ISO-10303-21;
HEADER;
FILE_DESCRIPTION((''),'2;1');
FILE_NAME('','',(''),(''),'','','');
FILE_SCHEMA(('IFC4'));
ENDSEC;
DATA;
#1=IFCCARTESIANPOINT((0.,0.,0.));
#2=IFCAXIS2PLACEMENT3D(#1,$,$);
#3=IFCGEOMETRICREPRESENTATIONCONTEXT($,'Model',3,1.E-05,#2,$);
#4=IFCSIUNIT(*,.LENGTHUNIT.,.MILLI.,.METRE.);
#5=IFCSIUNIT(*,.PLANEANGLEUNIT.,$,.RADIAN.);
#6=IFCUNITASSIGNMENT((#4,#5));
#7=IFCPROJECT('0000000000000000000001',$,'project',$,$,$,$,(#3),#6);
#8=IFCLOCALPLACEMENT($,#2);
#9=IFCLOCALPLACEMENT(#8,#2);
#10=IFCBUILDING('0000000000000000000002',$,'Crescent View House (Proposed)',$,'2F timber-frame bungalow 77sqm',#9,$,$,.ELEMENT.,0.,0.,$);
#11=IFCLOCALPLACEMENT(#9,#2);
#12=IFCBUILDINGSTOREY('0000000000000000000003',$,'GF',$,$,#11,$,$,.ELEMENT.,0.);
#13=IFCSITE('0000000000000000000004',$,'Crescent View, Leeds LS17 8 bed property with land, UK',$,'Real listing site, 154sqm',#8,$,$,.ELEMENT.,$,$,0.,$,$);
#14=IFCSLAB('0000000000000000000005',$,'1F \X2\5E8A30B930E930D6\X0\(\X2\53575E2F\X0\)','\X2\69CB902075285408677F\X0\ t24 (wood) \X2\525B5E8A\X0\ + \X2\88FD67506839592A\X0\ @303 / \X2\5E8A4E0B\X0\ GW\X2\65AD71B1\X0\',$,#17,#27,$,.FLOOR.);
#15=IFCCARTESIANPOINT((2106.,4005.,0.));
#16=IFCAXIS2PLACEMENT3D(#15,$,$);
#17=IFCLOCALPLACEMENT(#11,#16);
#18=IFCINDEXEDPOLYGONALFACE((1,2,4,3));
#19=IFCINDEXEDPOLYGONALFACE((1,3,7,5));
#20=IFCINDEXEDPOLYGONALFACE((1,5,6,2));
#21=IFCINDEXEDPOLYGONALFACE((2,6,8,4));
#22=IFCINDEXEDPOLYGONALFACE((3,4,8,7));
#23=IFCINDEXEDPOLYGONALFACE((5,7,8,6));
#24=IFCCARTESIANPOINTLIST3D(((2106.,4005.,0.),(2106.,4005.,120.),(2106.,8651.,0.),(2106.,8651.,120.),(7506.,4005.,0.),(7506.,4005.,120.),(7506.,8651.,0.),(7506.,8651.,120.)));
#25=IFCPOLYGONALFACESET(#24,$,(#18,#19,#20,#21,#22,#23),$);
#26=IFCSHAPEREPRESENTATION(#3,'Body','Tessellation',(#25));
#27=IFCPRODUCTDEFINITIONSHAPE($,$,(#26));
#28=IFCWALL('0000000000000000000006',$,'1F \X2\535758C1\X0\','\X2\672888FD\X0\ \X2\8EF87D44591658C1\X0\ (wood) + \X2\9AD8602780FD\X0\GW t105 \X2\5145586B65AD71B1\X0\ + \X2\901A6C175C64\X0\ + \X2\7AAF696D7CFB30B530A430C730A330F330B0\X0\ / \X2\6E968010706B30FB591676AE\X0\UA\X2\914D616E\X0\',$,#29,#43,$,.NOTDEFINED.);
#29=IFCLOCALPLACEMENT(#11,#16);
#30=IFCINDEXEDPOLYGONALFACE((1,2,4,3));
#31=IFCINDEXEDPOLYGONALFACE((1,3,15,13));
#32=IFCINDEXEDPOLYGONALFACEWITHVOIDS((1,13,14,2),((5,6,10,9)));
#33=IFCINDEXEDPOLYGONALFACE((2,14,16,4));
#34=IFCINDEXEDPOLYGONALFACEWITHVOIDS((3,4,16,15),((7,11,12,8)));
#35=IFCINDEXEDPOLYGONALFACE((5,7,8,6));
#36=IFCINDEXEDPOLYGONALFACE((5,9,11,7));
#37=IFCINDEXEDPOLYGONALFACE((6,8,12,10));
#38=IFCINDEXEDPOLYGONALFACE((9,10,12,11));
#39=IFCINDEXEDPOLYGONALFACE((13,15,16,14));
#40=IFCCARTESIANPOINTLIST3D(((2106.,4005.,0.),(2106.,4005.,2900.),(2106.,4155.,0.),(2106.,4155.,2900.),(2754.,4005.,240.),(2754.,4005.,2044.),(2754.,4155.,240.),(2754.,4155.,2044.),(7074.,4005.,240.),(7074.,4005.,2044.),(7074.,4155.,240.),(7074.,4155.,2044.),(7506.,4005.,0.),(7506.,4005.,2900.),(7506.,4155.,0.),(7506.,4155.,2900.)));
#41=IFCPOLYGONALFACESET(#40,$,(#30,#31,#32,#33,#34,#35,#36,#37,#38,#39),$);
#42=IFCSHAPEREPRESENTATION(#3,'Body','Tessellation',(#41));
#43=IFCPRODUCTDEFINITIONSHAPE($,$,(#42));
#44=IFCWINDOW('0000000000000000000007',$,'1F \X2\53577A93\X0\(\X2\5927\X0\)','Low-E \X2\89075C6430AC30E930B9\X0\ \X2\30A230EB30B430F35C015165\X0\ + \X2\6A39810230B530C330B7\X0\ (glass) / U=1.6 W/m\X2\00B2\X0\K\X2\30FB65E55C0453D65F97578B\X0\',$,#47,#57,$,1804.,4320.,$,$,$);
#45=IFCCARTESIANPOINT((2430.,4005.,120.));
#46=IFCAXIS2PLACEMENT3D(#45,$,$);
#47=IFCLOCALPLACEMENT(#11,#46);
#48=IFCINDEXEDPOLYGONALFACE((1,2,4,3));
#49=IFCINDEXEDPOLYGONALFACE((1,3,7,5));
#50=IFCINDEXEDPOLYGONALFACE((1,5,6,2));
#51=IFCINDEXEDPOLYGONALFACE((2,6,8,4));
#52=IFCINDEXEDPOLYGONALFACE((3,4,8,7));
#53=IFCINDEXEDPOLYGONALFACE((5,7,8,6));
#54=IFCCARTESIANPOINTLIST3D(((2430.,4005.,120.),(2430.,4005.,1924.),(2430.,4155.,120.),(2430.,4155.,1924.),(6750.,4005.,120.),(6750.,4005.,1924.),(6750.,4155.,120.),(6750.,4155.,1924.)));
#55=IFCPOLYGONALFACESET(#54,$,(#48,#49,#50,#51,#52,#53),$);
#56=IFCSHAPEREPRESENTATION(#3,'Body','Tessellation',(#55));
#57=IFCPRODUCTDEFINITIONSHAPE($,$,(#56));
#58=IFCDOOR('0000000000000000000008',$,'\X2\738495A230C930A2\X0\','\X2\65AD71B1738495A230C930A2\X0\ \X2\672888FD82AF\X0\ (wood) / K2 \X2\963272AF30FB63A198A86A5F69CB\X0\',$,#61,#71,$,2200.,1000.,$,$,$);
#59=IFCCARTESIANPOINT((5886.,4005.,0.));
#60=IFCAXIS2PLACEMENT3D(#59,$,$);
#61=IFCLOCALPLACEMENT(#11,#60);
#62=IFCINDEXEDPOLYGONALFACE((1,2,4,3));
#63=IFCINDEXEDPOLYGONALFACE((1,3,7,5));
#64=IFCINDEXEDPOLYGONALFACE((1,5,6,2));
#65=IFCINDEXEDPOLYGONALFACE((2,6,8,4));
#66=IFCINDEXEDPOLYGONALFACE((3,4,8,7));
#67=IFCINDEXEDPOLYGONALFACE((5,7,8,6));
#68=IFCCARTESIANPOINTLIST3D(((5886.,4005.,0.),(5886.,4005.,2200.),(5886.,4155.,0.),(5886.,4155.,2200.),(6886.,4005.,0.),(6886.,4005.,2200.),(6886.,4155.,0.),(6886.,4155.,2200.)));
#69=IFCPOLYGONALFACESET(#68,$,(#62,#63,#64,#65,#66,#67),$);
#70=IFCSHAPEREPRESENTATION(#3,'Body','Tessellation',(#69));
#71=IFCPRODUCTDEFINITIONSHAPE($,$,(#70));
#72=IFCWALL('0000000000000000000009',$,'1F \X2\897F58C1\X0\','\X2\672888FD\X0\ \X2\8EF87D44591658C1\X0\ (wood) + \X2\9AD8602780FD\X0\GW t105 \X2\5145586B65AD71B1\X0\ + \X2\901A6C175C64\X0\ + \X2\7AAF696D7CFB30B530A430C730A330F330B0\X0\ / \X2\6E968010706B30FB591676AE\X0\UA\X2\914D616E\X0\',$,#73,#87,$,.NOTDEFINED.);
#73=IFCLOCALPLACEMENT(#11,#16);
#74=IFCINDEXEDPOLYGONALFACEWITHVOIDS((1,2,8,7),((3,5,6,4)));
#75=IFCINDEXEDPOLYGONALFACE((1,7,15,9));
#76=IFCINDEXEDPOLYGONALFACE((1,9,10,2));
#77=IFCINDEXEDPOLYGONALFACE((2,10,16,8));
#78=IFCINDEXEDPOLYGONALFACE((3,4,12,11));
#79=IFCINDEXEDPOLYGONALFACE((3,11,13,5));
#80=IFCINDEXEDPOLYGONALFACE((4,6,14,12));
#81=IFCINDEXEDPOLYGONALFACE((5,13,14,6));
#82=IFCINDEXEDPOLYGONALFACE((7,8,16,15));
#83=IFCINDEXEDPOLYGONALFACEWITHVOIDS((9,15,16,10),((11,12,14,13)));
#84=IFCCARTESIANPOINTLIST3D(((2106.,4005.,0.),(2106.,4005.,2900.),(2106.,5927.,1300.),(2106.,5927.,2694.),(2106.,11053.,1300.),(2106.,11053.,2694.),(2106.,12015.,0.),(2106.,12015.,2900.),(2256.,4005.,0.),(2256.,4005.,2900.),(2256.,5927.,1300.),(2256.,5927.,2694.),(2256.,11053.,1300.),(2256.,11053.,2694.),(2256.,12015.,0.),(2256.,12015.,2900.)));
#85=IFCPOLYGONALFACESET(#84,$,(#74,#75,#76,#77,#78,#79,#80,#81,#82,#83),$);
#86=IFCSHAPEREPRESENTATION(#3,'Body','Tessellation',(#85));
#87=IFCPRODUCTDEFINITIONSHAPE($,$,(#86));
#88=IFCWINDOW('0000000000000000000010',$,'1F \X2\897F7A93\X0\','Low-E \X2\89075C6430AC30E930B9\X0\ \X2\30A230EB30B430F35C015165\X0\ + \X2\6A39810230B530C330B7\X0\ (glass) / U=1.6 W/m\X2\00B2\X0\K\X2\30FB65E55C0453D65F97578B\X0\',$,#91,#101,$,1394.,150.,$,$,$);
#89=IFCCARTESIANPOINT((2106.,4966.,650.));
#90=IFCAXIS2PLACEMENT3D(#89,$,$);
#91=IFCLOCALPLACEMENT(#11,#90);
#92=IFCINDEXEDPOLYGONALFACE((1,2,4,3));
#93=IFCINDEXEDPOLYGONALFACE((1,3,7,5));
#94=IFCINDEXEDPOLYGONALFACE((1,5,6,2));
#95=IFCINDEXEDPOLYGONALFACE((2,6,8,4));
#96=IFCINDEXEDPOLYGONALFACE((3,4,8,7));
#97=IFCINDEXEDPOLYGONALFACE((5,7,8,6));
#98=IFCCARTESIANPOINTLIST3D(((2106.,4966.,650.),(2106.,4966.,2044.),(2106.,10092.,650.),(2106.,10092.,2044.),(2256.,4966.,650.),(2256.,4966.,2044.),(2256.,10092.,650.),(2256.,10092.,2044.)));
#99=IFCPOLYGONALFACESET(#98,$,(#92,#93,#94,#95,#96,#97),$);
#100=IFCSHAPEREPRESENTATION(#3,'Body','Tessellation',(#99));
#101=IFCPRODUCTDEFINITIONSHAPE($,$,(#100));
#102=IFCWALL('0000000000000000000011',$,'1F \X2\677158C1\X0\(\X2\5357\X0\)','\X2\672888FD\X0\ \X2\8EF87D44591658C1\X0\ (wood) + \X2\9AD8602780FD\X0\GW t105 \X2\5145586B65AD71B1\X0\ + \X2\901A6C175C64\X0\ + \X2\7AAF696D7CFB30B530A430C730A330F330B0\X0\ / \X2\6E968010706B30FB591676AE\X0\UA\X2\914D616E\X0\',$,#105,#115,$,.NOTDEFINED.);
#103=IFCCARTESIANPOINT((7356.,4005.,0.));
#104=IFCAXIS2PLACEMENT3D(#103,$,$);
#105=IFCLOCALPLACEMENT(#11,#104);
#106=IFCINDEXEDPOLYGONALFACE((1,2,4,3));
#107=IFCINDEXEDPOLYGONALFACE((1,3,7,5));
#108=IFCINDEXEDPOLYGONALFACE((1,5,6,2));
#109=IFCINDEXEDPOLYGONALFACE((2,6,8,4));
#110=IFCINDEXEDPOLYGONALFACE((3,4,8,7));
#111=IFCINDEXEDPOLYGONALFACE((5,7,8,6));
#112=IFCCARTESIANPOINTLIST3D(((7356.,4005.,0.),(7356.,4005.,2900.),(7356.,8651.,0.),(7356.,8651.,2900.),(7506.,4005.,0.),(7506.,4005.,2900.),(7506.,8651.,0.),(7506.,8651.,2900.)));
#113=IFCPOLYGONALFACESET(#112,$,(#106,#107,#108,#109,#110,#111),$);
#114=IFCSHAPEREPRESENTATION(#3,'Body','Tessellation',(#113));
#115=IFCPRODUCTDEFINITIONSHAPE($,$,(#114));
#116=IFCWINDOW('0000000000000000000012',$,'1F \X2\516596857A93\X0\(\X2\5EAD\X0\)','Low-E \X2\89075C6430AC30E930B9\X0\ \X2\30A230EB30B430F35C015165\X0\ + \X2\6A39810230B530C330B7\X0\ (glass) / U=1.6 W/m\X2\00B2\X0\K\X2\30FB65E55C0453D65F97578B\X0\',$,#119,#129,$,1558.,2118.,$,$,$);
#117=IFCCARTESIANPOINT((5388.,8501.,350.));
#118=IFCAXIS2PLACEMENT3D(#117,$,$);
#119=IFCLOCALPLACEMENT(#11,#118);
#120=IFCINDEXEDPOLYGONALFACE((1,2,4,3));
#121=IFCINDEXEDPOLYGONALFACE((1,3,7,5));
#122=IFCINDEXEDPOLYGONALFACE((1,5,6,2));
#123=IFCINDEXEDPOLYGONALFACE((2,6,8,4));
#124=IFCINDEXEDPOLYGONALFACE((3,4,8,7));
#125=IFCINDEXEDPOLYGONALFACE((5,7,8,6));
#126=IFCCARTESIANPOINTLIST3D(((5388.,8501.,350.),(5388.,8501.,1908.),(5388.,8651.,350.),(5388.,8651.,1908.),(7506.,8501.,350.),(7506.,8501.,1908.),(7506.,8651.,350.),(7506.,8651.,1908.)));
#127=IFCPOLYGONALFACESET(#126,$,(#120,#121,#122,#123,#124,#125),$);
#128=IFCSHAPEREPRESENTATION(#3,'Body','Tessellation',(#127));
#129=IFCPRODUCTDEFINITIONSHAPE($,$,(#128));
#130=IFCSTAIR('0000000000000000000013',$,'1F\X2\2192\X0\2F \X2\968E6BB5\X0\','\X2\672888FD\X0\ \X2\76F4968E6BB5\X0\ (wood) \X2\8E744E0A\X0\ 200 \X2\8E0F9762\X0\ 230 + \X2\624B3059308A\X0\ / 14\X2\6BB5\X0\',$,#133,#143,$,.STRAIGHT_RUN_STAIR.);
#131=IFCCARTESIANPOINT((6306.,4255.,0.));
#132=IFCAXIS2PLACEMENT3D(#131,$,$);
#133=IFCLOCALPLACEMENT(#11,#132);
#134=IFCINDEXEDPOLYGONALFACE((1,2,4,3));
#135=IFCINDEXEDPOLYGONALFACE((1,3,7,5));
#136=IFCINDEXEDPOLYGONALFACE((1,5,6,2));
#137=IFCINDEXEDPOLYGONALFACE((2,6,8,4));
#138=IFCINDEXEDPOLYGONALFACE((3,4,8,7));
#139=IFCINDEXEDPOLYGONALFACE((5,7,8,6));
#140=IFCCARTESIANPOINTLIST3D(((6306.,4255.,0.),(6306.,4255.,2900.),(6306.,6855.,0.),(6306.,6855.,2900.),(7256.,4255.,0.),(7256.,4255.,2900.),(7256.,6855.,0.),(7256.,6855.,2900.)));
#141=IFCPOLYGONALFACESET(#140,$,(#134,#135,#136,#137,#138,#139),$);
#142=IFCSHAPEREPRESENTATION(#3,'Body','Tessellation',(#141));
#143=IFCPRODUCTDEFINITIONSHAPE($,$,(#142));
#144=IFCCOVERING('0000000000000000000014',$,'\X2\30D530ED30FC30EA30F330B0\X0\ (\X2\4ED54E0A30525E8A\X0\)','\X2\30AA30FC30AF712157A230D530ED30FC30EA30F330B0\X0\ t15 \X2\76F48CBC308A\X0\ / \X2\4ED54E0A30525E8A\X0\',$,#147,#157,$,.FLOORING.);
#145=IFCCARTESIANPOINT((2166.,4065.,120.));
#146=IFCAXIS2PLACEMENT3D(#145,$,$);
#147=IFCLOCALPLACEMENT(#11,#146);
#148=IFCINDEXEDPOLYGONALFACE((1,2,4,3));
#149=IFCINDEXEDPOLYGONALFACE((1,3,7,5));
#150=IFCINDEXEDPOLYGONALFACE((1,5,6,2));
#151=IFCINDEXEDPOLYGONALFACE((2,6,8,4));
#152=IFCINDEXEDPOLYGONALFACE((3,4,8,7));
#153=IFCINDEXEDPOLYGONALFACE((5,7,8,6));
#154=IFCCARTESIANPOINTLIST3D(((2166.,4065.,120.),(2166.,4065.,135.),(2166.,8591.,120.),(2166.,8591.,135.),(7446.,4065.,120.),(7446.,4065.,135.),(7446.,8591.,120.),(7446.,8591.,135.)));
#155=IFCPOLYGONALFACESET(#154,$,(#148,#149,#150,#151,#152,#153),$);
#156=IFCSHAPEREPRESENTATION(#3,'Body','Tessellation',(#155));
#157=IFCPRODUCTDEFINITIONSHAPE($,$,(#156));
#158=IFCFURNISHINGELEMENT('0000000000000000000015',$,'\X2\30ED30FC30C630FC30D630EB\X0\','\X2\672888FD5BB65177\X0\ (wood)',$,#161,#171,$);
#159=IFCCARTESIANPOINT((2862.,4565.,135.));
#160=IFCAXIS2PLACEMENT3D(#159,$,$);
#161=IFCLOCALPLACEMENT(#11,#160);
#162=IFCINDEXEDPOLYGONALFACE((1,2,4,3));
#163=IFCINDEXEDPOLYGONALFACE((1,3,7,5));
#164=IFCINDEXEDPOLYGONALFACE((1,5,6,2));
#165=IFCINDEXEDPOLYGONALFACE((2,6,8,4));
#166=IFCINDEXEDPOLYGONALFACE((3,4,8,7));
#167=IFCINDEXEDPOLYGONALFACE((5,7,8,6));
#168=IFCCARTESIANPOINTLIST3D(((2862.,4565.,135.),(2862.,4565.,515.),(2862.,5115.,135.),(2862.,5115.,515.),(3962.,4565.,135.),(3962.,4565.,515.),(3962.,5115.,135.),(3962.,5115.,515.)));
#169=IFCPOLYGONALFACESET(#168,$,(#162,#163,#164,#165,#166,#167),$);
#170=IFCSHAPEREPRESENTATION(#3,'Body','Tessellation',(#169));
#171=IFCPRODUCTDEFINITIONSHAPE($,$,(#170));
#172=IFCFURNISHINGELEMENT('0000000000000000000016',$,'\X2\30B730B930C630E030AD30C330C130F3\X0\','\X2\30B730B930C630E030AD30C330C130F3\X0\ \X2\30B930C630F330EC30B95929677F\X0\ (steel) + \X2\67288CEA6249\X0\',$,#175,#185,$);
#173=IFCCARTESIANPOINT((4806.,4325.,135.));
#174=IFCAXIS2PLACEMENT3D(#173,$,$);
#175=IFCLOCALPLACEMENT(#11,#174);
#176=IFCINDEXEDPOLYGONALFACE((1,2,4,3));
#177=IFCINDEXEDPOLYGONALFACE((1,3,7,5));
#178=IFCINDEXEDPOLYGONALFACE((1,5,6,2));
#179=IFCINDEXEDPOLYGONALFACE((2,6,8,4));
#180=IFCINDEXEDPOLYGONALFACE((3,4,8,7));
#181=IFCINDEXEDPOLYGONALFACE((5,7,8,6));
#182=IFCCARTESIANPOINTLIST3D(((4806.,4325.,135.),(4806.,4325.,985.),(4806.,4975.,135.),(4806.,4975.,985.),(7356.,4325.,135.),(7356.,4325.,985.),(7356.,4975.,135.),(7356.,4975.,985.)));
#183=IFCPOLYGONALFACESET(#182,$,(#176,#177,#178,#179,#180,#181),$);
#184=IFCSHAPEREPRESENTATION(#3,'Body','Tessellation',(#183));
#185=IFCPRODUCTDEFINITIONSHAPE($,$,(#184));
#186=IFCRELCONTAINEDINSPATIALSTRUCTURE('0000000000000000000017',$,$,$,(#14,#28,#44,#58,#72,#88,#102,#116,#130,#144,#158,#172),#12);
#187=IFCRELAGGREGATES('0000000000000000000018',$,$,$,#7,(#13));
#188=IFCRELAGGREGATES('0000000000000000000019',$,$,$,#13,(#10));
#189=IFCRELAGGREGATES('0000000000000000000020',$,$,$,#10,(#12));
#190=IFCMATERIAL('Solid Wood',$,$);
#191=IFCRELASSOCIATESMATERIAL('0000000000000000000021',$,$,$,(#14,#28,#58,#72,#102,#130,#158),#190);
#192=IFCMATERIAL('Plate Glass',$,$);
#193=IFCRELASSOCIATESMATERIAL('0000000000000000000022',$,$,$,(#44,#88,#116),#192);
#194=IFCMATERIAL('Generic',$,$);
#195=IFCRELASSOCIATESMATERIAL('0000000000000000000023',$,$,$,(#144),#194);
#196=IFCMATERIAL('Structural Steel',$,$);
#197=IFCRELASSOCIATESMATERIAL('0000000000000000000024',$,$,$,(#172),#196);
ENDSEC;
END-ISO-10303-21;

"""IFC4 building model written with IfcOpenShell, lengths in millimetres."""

from ifc_helpers import new_model, si_unit, frame, frame_2d, origin, place, context, project, spatial, rectangle, extrude, material, element, fill, save


model = new_model("IFC4")

# Units and contexts
model_context = context("Model", 3, precision=1e-05, world=origin())
ifc_project = project(units=[si_unit("LENGTHUNIT", "METRE", prefix="MILLI"), si_unit("PLANEANGLEUNIT", "RADIAN")], contexts=[model_context])

# Site, building, storey
site_placement = place(None, origin())
site = spatial("IfcSite", under=ifc_project, at=site_placement, Name="Crescent View, Leeds LS17 8 bed property with land, UK", ObjectType="Real listing site, 154sqm", CompositionType="ELEMENT", RefElevation=0.0)
building_placement = place(site_placement, origin())
building = spatial("IfcBuilding", under=site, at=building_placement, Name="Crescent View House (Proposed)", ObjectType="2F timber-frame bungalow 77sqm", CompositionType="ELEMENT", ElevationOfRefHeight=0.0, ElevationOfTerrain=0.0)
storey_placement = place(building_placement, origin())
storey = spatial("IfcBuildingStorey", under=building, at=storey_placement, Name="GF", CompositionType="ELEMENT", Elevation=0.0)

# Slab
ifc_material_1 = material(Name="Solid Wood")
slab_1_placement = place(storey_placement, frame((2106.0, 4005.0, 0.0)))
element("IfcSlab", 1, at=slab_1_placement, inside=storey, material=ifc_material_1, Name="1F 床スラブ(南帯)", Description="構造用合板 t24 (wood) 剛床 + 製材根太 @303 / 床下 GW断熱", PredefinedType="FLOOR", context=model_context, shape_type="SweptSolid", body=[
    extrude(rectangle(XDim=5400.0, YDim=4646.0, at=frame_2d((2700.0, 2323.0))), frame((2106.0, 4005.0, 0.0)), (0.0, 0.0, 1.0), 120.0),
])

# Wall, openings, window, door
wall_1_placement = place(storey_placement, frame((2106.0, 4005.0, 0.0)))
wall_1 = element("IfcWall", 2, at=wall_1_placement, inside=storey, material=ifc_material_1, Name="1F 南壁", Description="木製 軸組外壁 (wood) + 高性能GW t105 充填断熱 + 通気層 + 窯業系サイディング / 準耐火・外皮UA配慮", PredefinedType="NOTDEFINED", context=model_context, shape_type="SweptSolid", body=[
    extrude(rectangle(XDim=5400.0, YDim=150.0, at=frame_2d((2700.0, 75.0))), frame((2106.0, 4005.0, 0.0)), (0.0, 0.0, 1.0), 2900.0),
])
opening_1_placement = place(storey_placement, frame((2430.0, 4005.0, 120.0)))
opening_1 = element("IfcOpeningElement", 3, at=opening_1_placement, cuts=wall_1, PredefinedType="NOTDEFINED", context=model_context, shape_type="SweptSolid", body=[
    extrude(rectangle(XDim=4320.0, YDim=150.0, at=frame_2d((2160.0, 75.0))), frame((2430.0, 4005.0, 120.0)), (0.0, 0.0, 1.0), 1804.0),
])
opening_2_placement = place(storey_placement, frame((5886.0, 4005.0, 0.0)))
opening_2 = element("IfcOpeningElement", 4, at=opening_2_placement, cuts=wall_1, PredefinedType="NOTDEFINED", context=model_context, shape_type="SweptSolid", body=[
    extrude(rectangle(XDim=1000.0, YDim=150.0, at=frame_2d((500.0, 75.0))), frame((5886.0, 4005.0, 0.0)), (0.0, 0.0, 1.0), 2200.0),
])
ifc_material_2 = material(Name="Plate Glass")
window_1_placement = place(storey_placement, frame((2430.0, 4005.0, 120.0)))
window_1 = element("IfcWindow", 5, at=window_1_placement, inside=storey, material=ifc_material_2, Name="1F 南窓(大)", Description="Low-E 複層ガラス アルゴン封入 + 樹脂サッシ (glass) / U=1.6 W/m²K・日射取得型", OverallHeight=1804.0, OverallWidth=4320.0, context=model_context, shape_type="SweptSolid", body=[
    extrude(rectangle(XDim=4320.0, YDim=150.0, at=frame_2d((2160.0, 75.0))), frame((2430.0, 4005.0, 120.0)), (0.0, 0.0, 1.0), 1804.0),
])
fill(opening_1, window_1)
door_1_placement = place(storey_placement, frame((5886.0, 4005.0, 0.0)))
door_1 = element("IfcDoor", 6, at=door_1_placement, inside=storey, material=ifc_material_1, Name="玄関ドア", Description="断熱玄関ドア 木製芯 (wood) / K2 防犯・採風機構", OverallHeight=2200.0, OverallWidth=1000.0, context=model_context, shape_type="SweptSolid", body=[
    extrude(rectangle(XDim=1000.0, YDim=150.0, at=frame_2d((500.0, 75.0))), frame((5886.0, 4005.0, 0.0)), (0.0, 0.0, 1.0), 2200.0),
])
fill(opening_2, door_1)

# Walls, openings, windows
wall_2_placement = place(storey_placement, frame((2106.0, 4005.0, 0.0)))
wall_2 = element("IfcWall", 7, at=wall_2_placement, inside=storey, material=ifc_material_1, Name="1F 西壁", Description="木製 軸組外壁 (wood) + 高性能GW t105 充填断熱 + 通気層 + 窯業系サイディング / 準耐火・外皮UA配慮", PredefinedType="NOTDEFINED", context=model_context, shape_type="SweptSolid", body=[
    extrude(rectangle(XDim=150.0, YDim=8010.0, at=frame_2d((75.0, 4005.0))), frame((2106.0, 4005.0, 0.0)), (0.0, 0.0, 1.0), 2900.0),
])
opening_3_placement = place(storey_placement, frame((2106.0, 4966.0, 650.0)))
opening_3 = element("IfcOpeningElement", 8, at=opening_3_placement, cuts=wall_2, PredefinedType="NOTDEFINED", context=model_context, shape_type="SweptSolid", body=[
    extrude(rectangle(XDim=150.0, YDim=5126.0, at=frame_2d((75.0, 2563.0))), frame((2106.0, 4966.0, 650.0)), (0.0, 0.0, 1.0), 1394.0),
])
window_2_placement = place(storey_placement, frame((2106.0, 4966.0, 650.0)))
window_2 = element("IfcWindow", 9, at=window_2_placement, inside=storey, material=ifc_material_2, Name="1F 西窓", Description="Low-E 複層ガラス アルゴン封入 + 樹脂サッシ (glass) / U=1.6 W/m²K・日射取得型", OverallHeight=1394.0, OverallWidth=150.0, context=model_context, shape_type="SweptSolid", body=[
    extrude(rectangle(XDim=150.0, YDim=5126.0, at=frame_2d((75.0, 2563.0))), frame((2106.0, 4966.0, 650.0)), (0.0, 0.0, 1.0), 1394.0),
])
fill(opening_3, window_2)
wall_3_placement = place(storey_placement, frame((7356.0, 4005.0, 0.0)))
wall_3 = element("IfcWall", 10, at=wall_3_placement, inside=storey, material=ifc_material_1, Name="1F 東壁(南)", Description="木製 軸組外壁 (wood) + 高性能GW t105 充填断熱 + 通気層 + 窯業系サイディング / 準耐火・外皮UA配慮", PredefinedType="NOTDEFINED", context=model_context, shape_type="SweptSolid", body=[
    extrude(rectangle(XDim=150.0, YDim=4646.0, at=frame_2d((75.0, 2323.0))), frame((7356.0, 4005.0, 0.0)), (0.0, 0.0, 1.0), 2900.0),
])
opening_4_placement = place(storey_placement, frame((5388.0, 8501.0, 350.0)))
opening_4 = element("IfcOpeningElement", 11, at=opening_4_placement, cuts=wall_3, PredefinedType="NOTDEFINED", context=model_context, shape_type="SweptSolid", body=[
    extrude(rectangle(XDim=2118.0, YDim=150.0, at=frame_2d((1059.0, 75.0))), frame((5388.0, 8501.0, 350.0)), (0.0, 0.0, 1.0), 1558.0),
])
window_3_placement = place(storey_placement, frame((5388.0, 8501.0, 350.0)))
window_3 = element("IfcWindow", 12, at=window_3_placement, inside=storey, material=ifc_material_2, Name="1F 入隅窓(庭)", Description="Low-E 複層ガラス アルゴン封入 + 樹脂サッシ (glass) / U=1.6 W/m²K・日射取得型", OverallHeight=1558.0, OverallWidth=2118.0, context=model_context, shape_type="SweptSolid", body=[
    extrude(rectangle(XDim=2118.0, YDim=150.0, at=frame_2d((1059.0, 75.0))), frame((5388.0, 8501.0, 350.0)), (0.0, 0.0, 1.0), 1558.0),
])
fill(opening_4, window_3)

# Stair
stair_placement = place(storey_placement, frame((6306.0, 4255.0, 0.0)))
element("IfcStair", 13, at=stair_placement, inside=storey, material=ifc_material_1, Name="1F→2F 階段", Description="木製 直階段 (wood) 蹴上 200 踏面 230 + 手すり / 14段", PredefinedType="STRAIGHT_RUN_STAIR", context=model_context, shape_type="SweptSolid", body=[
    extrude(rectangle(XDim=950.0, YDim=2600.0, at=frame_2d((475.0, 1300.0))), frame((6306.0, 4255.0, 0.0)), (0.0, 0.0, 1.0), 2900.0),
])

# Covering
ifc_material_3 = material(Name="Generic")
covering_placement = place(storey_placement, frame((2166.0, 4065.0, 120.0)))
element("IfcCovering", 14, at=covering_placement, inside=storey, material=ifc_material_3, Name="フローリング (仕上げ床)", Description="オーク無垢フローリング t15 直貼り / 仕上げ床", PredefinedType="FLOORING", context=model_context, shape_type="SweptSolid", body=[
    extrude(rectangle(XDim=5280.0, YDim=4526.0, at=frame_2d((2640.0, 2263.0))), frame((2166.0, 4065.0, 120.0)), (0.0, 0.0, 1.0), 15.0),
])

# Furnishing elements
furnishing_1_placement = place(storey_placement, frame((2862.0, 4565.0, 135.0)))
element("IfcFurnishingElement", 15, at=furnishing_1_placement, inside=storey, material=ifc_material_1, Name="ローテーブル", Description="木製家具 (wood)", context=model_context, shape_type="SweptSolid", body=[
    extrude(rectangle(XDim=1100.0, YDim=550.0, at=frame_2d((550.0, 275.0))), frame((2862.0, 4565.0, 135.0)), (0.0, 0.0, 1.0), 380.0),
])
ifc_material_4 = material(Name="Structural Steel")
furnishing_2_placement = place(storey_placement, frame((4806.0, 4325.0, 135.0)))
element("IfcFurnishingElement", 16, at=furnishing_2_placement, inside=storey, material=ifc_material_4, Name="システムキッチン", Description="システムキッチン ステンレス天板 (steel) + 木質扉", context=model_context, shape_type="SweptSolid", body=[
    extrude(rectangle(XDim=2550.0, YDim=650.0, at=frame_2d((1275.0, 325.0))), frame((4806.0, 4325.0, 135.0)), (0.0, 0.0, 1.0), 850.0),
])

save(model, "model.ifc")
